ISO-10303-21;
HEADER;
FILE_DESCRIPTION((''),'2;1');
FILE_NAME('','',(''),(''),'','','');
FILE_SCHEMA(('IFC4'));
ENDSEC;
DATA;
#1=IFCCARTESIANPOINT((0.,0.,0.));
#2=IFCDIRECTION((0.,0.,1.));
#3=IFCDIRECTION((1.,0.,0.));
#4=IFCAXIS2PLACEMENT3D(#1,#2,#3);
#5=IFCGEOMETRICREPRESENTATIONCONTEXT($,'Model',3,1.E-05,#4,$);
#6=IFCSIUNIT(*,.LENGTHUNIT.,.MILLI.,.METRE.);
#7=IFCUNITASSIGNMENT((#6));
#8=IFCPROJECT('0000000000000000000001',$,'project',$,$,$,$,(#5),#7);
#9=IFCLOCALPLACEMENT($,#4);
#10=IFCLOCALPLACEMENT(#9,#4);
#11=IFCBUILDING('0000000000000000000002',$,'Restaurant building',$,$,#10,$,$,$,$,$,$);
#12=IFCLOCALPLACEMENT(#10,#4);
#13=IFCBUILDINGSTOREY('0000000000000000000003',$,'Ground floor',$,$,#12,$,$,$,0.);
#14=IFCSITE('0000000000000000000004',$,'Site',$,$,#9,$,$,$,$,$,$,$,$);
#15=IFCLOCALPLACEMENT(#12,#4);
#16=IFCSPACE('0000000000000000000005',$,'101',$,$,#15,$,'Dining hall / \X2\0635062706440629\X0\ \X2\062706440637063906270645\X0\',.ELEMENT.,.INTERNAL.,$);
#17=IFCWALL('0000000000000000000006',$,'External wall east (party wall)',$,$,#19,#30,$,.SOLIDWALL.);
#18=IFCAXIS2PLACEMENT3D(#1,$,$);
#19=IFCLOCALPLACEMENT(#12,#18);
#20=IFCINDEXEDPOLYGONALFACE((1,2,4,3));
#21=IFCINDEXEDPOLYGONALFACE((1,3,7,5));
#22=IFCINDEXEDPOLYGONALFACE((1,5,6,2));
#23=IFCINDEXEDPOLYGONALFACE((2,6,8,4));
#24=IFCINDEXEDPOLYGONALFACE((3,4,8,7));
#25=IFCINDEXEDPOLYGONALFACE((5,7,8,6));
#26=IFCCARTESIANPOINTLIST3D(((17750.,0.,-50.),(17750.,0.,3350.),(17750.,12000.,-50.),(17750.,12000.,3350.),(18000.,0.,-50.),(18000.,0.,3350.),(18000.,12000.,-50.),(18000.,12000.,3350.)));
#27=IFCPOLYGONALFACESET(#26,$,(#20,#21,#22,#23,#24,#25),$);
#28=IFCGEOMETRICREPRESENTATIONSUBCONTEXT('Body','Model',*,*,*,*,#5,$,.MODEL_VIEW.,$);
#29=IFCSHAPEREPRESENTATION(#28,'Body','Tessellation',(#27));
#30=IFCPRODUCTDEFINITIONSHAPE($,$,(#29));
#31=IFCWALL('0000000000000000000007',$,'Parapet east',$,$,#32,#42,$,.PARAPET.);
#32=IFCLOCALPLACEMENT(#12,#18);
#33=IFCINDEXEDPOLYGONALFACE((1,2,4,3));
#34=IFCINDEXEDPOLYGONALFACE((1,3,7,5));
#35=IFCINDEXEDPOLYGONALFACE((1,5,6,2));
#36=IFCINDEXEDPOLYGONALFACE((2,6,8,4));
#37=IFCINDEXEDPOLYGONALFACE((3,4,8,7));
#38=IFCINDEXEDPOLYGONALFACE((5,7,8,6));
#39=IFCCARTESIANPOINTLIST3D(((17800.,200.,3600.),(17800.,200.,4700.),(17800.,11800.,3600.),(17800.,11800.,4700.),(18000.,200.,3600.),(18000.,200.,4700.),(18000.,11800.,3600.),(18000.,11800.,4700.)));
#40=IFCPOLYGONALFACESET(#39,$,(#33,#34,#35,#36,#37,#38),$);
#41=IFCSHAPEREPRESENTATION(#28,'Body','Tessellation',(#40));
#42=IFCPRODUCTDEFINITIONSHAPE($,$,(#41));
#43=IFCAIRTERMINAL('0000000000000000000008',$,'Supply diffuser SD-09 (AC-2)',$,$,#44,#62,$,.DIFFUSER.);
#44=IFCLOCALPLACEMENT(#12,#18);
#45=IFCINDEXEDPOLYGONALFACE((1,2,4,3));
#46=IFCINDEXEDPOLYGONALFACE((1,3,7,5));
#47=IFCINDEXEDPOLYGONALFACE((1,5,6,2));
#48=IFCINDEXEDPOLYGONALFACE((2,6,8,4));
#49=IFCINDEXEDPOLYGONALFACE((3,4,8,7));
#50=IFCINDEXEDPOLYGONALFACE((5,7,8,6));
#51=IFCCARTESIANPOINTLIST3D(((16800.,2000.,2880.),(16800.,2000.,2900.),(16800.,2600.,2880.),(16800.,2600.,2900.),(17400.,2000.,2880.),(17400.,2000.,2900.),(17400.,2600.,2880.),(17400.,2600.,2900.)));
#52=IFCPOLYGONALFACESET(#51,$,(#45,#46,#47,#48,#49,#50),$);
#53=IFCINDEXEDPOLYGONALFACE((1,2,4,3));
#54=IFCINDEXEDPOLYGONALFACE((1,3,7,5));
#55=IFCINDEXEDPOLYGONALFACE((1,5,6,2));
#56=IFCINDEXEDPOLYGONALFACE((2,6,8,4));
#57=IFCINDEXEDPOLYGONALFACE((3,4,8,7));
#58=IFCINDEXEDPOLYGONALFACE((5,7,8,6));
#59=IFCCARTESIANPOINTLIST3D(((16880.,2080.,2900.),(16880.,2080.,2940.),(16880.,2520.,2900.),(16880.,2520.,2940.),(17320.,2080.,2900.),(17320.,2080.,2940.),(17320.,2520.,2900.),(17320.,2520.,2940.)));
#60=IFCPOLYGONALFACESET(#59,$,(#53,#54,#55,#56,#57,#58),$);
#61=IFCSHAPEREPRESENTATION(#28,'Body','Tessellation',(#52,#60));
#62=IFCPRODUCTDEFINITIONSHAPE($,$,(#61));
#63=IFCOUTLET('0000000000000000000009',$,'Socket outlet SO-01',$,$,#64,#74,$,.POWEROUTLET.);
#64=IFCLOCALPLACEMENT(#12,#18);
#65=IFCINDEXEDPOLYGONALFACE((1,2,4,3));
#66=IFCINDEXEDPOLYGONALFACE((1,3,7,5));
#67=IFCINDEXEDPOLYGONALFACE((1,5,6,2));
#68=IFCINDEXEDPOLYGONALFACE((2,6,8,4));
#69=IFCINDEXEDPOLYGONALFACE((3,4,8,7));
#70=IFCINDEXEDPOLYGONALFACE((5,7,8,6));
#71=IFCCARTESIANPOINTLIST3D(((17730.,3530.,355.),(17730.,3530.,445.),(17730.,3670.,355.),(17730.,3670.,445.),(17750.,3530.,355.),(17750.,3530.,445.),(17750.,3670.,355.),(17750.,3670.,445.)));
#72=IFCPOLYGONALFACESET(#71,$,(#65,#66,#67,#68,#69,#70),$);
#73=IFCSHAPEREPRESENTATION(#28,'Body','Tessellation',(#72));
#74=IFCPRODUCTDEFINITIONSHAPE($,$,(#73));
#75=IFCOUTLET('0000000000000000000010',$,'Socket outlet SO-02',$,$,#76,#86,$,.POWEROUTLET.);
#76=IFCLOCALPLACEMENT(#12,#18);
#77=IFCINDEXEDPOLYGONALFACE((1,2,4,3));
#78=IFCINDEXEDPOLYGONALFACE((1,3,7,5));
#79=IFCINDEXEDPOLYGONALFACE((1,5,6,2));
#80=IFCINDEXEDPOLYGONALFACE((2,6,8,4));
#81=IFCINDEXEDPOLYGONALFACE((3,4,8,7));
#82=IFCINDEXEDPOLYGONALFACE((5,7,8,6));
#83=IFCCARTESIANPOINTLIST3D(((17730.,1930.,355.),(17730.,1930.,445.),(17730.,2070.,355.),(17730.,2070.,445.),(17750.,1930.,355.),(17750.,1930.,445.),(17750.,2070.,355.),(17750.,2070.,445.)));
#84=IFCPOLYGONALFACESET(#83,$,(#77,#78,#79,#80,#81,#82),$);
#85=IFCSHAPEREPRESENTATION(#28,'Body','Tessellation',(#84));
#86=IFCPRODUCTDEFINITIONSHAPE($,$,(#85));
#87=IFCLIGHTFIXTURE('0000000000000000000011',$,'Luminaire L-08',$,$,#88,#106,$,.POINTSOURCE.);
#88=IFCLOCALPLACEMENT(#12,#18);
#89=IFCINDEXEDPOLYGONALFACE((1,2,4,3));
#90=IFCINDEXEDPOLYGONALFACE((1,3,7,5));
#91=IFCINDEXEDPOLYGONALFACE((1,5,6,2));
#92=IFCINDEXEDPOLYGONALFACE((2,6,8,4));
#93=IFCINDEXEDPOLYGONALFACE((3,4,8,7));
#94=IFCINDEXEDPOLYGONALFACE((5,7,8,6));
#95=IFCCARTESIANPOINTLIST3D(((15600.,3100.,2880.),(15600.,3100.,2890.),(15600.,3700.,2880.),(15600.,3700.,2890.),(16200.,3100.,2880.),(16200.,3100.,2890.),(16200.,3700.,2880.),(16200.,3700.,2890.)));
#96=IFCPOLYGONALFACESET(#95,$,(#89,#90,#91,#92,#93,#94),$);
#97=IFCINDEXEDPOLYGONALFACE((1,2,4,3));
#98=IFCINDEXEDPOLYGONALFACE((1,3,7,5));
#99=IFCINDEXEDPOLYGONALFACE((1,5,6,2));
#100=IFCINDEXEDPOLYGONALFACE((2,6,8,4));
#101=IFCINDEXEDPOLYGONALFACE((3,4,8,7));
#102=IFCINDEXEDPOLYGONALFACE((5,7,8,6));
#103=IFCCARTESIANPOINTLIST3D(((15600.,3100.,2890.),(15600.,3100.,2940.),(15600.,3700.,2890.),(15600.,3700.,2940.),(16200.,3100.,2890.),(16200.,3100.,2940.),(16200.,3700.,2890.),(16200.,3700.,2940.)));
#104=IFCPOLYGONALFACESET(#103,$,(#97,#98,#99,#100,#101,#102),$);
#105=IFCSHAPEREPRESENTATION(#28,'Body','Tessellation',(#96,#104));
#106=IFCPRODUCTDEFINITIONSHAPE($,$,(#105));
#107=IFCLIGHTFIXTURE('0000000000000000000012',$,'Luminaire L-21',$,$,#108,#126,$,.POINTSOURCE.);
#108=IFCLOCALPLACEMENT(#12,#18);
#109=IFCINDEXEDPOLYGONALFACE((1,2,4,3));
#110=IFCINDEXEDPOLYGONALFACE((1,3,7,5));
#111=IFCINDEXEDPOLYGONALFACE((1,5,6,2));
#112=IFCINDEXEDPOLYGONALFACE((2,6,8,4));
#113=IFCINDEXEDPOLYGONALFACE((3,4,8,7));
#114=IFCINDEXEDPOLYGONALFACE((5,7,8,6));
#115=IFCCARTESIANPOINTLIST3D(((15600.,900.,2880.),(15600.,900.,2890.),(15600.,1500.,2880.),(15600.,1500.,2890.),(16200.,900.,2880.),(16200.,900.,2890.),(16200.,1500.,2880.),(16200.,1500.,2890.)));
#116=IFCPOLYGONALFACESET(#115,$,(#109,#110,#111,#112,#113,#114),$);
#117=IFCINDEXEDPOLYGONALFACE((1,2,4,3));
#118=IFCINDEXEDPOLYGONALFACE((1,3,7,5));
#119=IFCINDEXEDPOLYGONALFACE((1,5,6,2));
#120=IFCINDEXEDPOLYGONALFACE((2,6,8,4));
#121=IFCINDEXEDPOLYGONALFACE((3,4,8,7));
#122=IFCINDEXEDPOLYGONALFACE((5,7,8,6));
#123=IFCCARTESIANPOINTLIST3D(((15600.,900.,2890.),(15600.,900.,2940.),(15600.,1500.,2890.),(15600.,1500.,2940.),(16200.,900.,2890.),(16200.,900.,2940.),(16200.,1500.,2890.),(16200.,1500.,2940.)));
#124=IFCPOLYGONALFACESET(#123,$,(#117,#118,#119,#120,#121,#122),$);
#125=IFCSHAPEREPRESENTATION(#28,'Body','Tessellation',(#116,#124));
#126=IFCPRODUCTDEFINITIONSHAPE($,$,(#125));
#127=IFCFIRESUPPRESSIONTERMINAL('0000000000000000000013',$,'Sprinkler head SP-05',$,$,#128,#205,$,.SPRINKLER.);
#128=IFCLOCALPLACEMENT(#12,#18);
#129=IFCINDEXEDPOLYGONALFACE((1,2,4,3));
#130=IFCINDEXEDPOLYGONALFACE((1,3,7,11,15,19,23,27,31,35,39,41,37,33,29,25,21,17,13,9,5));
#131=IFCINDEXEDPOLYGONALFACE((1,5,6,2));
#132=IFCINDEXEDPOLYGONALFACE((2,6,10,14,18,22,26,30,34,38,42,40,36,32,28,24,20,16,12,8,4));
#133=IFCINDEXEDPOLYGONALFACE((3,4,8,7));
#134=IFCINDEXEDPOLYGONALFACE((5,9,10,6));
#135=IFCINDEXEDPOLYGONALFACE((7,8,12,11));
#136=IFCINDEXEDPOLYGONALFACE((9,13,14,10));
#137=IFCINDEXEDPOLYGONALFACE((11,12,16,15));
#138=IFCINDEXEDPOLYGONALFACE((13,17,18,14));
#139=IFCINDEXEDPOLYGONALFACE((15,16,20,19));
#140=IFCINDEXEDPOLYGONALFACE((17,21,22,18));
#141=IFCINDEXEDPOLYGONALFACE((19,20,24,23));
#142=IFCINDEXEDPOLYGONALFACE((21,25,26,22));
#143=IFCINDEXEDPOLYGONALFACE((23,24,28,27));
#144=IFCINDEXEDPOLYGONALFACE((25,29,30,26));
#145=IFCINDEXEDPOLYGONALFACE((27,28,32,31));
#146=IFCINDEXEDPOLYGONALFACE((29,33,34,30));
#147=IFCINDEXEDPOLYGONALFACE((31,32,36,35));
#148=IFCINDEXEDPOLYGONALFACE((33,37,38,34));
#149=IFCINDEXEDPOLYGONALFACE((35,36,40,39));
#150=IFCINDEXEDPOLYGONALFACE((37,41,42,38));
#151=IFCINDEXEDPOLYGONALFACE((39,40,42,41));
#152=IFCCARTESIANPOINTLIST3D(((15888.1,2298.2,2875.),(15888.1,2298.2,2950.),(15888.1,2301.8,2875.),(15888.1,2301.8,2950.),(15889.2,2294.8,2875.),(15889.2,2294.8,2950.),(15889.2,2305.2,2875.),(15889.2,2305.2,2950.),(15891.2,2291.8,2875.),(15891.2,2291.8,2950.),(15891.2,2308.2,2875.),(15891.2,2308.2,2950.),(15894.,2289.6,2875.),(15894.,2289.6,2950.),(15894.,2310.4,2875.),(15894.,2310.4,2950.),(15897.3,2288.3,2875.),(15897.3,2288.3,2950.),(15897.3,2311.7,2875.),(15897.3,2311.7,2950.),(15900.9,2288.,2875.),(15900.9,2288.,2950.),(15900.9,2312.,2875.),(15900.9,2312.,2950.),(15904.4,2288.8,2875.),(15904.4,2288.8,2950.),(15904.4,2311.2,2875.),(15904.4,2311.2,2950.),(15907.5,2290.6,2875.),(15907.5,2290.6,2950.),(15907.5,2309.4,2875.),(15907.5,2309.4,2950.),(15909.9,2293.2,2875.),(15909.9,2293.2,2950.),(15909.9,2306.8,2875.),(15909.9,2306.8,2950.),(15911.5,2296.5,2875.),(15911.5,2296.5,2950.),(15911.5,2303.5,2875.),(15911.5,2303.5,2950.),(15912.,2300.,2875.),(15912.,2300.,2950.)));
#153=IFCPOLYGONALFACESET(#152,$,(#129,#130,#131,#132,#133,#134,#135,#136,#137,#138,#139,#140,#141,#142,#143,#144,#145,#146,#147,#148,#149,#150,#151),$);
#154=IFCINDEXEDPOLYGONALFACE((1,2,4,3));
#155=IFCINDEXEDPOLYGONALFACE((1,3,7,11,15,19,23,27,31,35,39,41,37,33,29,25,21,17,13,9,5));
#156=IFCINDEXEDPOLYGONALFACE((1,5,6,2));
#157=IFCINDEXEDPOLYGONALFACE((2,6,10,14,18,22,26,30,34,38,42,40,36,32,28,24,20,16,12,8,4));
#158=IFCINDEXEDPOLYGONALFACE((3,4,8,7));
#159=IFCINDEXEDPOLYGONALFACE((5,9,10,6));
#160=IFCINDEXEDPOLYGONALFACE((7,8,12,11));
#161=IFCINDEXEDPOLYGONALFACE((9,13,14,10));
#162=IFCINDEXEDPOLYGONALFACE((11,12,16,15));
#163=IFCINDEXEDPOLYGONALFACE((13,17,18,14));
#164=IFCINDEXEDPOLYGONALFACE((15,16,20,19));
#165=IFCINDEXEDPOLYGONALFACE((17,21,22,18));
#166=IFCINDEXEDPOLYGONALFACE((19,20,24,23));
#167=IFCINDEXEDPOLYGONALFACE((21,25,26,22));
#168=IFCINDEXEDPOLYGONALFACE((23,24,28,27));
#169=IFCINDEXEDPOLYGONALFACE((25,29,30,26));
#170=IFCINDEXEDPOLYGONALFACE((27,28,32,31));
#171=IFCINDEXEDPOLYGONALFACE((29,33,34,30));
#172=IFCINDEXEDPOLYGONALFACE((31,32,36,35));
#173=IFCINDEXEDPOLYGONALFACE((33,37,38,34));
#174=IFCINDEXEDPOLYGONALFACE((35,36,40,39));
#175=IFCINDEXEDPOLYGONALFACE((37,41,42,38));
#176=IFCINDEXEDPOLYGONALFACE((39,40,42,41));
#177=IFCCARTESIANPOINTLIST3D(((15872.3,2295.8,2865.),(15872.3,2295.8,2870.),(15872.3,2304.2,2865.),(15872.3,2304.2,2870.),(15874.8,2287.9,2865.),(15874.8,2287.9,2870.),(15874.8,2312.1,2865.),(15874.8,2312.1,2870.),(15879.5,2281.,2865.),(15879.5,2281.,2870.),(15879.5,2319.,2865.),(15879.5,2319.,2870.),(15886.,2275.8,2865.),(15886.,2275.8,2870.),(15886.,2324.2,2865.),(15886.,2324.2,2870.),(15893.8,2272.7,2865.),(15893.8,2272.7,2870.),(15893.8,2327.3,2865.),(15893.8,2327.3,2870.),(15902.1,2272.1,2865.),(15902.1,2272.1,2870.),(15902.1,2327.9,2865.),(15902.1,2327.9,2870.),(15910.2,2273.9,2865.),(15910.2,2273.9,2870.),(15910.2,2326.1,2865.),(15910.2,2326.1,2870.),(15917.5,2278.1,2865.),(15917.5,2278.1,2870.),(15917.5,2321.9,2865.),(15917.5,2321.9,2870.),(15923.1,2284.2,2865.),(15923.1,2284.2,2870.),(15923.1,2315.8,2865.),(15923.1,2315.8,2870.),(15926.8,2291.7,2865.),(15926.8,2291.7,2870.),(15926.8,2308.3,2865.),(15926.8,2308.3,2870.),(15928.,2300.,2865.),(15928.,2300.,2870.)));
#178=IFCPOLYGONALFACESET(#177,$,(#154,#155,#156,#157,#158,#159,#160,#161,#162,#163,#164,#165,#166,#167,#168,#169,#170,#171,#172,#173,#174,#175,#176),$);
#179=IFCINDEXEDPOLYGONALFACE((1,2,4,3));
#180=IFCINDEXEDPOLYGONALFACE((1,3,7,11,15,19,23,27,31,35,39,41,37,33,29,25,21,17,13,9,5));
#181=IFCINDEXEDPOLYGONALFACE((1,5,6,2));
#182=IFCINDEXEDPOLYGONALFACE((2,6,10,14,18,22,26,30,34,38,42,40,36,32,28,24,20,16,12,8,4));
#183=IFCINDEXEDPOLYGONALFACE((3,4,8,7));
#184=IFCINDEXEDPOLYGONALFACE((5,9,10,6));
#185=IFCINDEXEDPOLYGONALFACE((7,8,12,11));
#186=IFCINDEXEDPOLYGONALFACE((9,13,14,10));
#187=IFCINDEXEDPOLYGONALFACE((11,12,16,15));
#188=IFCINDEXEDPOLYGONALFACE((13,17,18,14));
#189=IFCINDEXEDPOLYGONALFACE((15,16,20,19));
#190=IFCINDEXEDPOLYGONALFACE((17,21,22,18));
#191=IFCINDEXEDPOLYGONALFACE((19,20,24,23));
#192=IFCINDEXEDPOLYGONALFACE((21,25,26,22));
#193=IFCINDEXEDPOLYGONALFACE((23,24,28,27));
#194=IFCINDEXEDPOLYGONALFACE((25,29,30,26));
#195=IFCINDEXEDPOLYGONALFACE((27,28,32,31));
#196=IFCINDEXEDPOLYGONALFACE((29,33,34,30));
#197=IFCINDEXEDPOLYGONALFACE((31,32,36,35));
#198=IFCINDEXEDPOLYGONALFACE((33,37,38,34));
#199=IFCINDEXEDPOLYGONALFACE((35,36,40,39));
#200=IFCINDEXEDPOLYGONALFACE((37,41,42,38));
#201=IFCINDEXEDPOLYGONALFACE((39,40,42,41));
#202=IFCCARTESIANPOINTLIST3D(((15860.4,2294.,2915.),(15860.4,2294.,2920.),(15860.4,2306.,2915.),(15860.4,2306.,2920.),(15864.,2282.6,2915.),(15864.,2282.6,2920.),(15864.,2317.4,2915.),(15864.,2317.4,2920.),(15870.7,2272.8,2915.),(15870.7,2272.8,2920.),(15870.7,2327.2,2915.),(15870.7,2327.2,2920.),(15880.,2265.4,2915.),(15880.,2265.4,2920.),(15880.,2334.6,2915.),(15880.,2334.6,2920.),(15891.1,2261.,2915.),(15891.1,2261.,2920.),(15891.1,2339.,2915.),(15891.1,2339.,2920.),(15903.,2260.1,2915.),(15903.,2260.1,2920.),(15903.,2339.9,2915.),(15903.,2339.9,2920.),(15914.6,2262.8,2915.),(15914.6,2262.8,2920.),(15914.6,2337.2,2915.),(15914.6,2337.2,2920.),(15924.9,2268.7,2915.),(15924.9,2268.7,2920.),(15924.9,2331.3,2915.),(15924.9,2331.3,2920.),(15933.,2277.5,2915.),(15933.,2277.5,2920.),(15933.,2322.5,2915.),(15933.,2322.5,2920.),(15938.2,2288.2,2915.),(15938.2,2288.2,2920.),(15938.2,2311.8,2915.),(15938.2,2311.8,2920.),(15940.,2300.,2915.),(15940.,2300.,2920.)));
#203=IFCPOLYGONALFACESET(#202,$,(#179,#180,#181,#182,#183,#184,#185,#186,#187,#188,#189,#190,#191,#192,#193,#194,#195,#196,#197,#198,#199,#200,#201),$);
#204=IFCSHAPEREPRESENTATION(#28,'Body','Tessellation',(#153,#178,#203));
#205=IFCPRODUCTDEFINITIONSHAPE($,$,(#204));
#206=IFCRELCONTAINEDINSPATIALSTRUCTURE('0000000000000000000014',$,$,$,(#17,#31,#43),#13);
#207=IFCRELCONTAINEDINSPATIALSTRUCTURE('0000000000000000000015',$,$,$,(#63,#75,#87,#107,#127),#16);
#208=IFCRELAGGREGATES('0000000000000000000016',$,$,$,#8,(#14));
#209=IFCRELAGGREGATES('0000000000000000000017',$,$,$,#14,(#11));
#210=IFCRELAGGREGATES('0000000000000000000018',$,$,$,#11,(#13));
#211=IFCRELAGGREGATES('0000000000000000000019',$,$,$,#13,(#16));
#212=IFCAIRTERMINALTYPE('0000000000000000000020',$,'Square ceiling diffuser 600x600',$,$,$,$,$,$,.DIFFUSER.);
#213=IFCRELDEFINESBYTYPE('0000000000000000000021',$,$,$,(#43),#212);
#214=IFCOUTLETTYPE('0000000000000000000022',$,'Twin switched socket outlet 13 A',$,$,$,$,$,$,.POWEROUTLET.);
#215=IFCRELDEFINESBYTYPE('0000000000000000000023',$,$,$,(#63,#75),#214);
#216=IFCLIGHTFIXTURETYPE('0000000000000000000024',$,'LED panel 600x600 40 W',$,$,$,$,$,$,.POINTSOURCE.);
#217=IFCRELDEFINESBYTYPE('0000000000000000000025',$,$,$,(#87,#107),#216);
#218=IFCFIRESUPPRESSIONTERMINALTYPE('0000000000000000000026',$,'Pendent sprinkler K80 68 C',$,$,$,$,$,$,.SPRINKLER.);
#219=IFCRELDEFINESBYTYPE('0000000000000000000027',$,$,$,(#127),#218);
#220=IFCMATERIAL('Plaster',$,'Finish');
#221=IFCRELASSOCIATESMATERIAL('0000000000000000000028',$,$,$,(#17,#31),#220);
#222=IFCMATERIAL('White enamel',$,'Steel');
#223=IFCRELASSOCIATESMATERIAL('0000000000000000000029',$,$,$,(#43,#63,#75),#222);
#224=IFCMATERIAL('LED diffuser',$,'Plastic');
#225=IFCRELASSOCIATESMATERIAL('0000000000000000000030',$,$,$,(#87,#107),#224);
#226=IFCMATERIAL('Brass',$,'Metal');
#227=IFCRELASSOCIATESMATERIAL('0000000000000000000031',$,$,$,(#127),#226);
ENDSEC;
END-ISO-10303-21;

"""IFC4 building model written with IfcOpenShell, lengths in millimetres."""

from ifc_helpers import new_model, si_unit, frame, origin, origin_with_axes, origin_2d, place, context, subcontext, project, spatial, rectangle, circle, extrude, source, transform, mapped, material, type_object, type_shapes, element, save


model = new_model("IFC4")

# Units and contexts
model_context = context("Model", 3, precision=1e-05, world=origin_with_axes())
body_context = subcontext(model_context, "Body", "Model", "MODEL_VIEW")
ifc_project = project(units=[si_unit("LENGTHUNIT", "METRE", prefix="MILLI")], contexts=[model_context])

# Site, building, storey
site_placement = place(None, origin_with_axes())
site = spatial("IfcSite", under=ifc_project, at=site_placement, Name="Site")
building_placement = place(site_placement, origin_with_axes())
building = spatial("IfcBuilding", under=site, at=building_placement, Name="Restaurant building")
storey_placement = place(building_placement, origin_with_axes())
storey = spatial("IfcBuildingStorey", under=building, at=storey_placement, Name="Ground floor", Elevation=0.0)

# Walls
ifc_material_1 = material(Name="Plaster", Category="Finish")
wall_1_placement = place(storey_placement, frame((17875.0, 0.0, 0.0), z_axis=(0.0, 0.0, 1.0), x_axis=(0.0, 1.0, 0.0)))
element("IfcWall", 1, at=wall_1_placement, inside=storey, material=ifc_material_1, Name="External wall east (party wall)", PredefinedType="SOLIDWALL", context=body_context, shape_type="SweptSolid", body=[
    extrude(rectangle(XDim=12000.0, YDim=250.0, at=origin_2d()), frame((6000.0, 0.0, -50.0)), (0.0, 0.0, 1.0), 3400.0),
])
wall_2_placement = place(storey_placement, frame((17900.0, 200.0, 0.0), z_axis=(0.0, 0.0, 1.0), x_axis=(0.0, 1.0, 0.0)))
element("IfcWall", 2, at=wall_2_placement, inside=storey, material=ifc_material_1, Name="Parapet east", PredefinedType="PARAPET", context=body_context, shape_type="SweptSolid", body=[
    extrude(rectangle(XDim=11600.0, YDim=200.0, at=origin_2d()), frame((5800.0, 0.0, 3600.0)), (0.0, 0.0, 1.0), 1100.0),
])

# Air terminal
ifc_material_2 = material(Name="White enamel", Category="Steel")
air_terminal_type = type_object("IfcAirTerminalType", Name="Square ceiling diffuser 600x600", PredefinedType="DIFFUSER")
shared_shape_1 = source(origin(), body_context, "Body", "SweptSolid", [
    extrude(rectangle(XDim=600.0, YDim=600.0, at=origin_2d()), frame((0.0, 0.0, -60.0)), (0.0, 0.0, 1.0), 20.0),
    extrude(rectangle(XDim=440.0, YDim=440.0, at=origin_2d()), frame((0.0, 0.0, -40.0)), (0.0, 0.0, 1.0), 40.0),
])
type_shapes(air_terminal_type, [shared_shape_1])
air_terminal_placement = place(storey_placement, frame((17100.0, 2300.0, 2940.0)))
element("IfcAirTerminal", 3, at=air_terminal_placement, inside=storey, type_object=air_terminal_type, material=ifc_material_2, Name="Supply diffuser SD-09 (AC-2)", PredefinedType="DIFFUSER", context=body_context, shape_type="MappedRepresentation", body=[
    mapped(shared_shape_1, transform((0.0, 0.0, 0.0))),
])

# Shared definitions
space_placement = place(storey_placement, origin_with_axes())
space = spatial("IfcSpace", under=storey, at=space_placement, Name="101", LongName="Dining hall / صالة الطعام", CompositionType="ELEMENT", PredefinedType="INTERNAL")

# Outlets
outlet_type = type_object("IfcOutletType", Name="Twin switched socket outlet 13 A", PredefinedType="POWEROUTLET")
shared_shape_2 = source(origin(), body_context, "Body", "SweptSolid", [
    extrude(rectangle(XDim=140.0, YDim=20.0, at=origin_2d()), frame((0.0, 10.0, -45.0)), (0.0, 0.0, 1.0), 90.0),
])
type_shapes(outlet_type, [shared_shape_2])
for number, where, z_axis, x_axis, name in (
    (4, (17750.0, 3600.0, 400.0), (0.0, 0.0, 1.0), (0.0, 1.0, 0.0), "Socket outlet SO-01"),
    (5, (17750.0, 2000.0, 400.0), (0.0, 0.0, 1.0), (0.0, 1.0, 0.0), "Socket outlet SO-02"),
):
    element("IfcOutlet", number, at=place(storey_placement, frame(where, z_axis=z_axis, x_axis=x_axis)), inside=space, type_object=outlet_type, material=ifc_material_2, Name=name, PredefinedType="POWEROUTLET", context=body_context, shape_type="MappedRepresentation", body=[
        mapped(shared_shape_2, transform((0.0, 0.0, 0.0))),
    ])

# Light fixtures
ifc_material_3 = material(Name="LED diffuser", Category="Plastic")
light_fixture_type = type_object("IfcLightFixtureType", Name="LED panel 600x600 40 W", PredefinedType="POINTSOURCE")
shared_shape_3 = source(origin(), body_context, "Body", "SweptSolid", [
    extrude(rectangle(XDim=600.0, YDim=600.0, at=origin_2d()), frame((0.0, 0.0, -60.0)), (0.0, 0.0, 1.0), 10.0),
    extrude(rectangle(XDim=600.0, YDim=600.0, at=origin_2d()), frame((0.0, 0.0, -50.0)), (0.0, 0.0, 1.0), 50.0),
])
type_shapes(light_fixture_type, [shared_shape_3])
for number, where, name in (
    (6, (15900.0, 3400.0, 2940.0), "Luminaire L-08"),
    (7, (15900.0, 1200.0, 2940.0), "Luminaire L-21"),
):
    element("IfcLightFixture", number, at=place(storey_placement, frame(where)), inside=space, type_object=light_fixture_type, material=ifc_material_3, Name=name, PredefinedType="POINTSOURCE", context=body_context, shape_type="MappedRepresentation", body=[
        mapped(shared_shape_3, transform((0.0, 0.0, 0.0))),
    ])

# Fire suppression terminal
ifc_material_4 = material(Name="Brass", Category="Metal")
fire_suppression_terminal_type = type_object("IfcFireSuppressionTerminalType", Name="Pendent sprinkler K80 68 C", PredefinedType="SPRINKLER")
shared_shape_4 = source(origin(), body_context, "Body", "SweptSolid", [
    extrude(circle(Radius=12.0, at=origin_2d()), frame((0.0, 0.0, -75.0)), (0.0, 0.0, 1.0), 75.0),
    extrude(circle(Radius=28.0, at=origin_2d()), frame((0.0, 0.0, -85.0)), (0.0, 0.0, 1.0), 5.0),
    extrude(circle(Radius=40.0, at=origin_2d()), frame((0.0, 0.0, -35.0)), (0.0, 0.0, 1.0), 5.0),
])
type_shapes(fire_suppression_terminal_type, [shared_shape_4])
fire_suppression_terminal_placement = place(storey_placement, frame((15900.0, 2300.0, 2950.0)))
element("IfcFireSuppressionTerminal", 8, at=fire_suppression_terminal_placement, inside=space, type_object=fire_suppression_terminal_type, material=ifc_material_4, Name="Sprinkler head SP-05", PredefinedType="SPRINKLER", context=body_context, shape_type="MappedRepresentation", body=[
    mapped(shared_shape_4, transform((0.0, 0.0, 0.0))),
])

save(model, "model.ifc")
